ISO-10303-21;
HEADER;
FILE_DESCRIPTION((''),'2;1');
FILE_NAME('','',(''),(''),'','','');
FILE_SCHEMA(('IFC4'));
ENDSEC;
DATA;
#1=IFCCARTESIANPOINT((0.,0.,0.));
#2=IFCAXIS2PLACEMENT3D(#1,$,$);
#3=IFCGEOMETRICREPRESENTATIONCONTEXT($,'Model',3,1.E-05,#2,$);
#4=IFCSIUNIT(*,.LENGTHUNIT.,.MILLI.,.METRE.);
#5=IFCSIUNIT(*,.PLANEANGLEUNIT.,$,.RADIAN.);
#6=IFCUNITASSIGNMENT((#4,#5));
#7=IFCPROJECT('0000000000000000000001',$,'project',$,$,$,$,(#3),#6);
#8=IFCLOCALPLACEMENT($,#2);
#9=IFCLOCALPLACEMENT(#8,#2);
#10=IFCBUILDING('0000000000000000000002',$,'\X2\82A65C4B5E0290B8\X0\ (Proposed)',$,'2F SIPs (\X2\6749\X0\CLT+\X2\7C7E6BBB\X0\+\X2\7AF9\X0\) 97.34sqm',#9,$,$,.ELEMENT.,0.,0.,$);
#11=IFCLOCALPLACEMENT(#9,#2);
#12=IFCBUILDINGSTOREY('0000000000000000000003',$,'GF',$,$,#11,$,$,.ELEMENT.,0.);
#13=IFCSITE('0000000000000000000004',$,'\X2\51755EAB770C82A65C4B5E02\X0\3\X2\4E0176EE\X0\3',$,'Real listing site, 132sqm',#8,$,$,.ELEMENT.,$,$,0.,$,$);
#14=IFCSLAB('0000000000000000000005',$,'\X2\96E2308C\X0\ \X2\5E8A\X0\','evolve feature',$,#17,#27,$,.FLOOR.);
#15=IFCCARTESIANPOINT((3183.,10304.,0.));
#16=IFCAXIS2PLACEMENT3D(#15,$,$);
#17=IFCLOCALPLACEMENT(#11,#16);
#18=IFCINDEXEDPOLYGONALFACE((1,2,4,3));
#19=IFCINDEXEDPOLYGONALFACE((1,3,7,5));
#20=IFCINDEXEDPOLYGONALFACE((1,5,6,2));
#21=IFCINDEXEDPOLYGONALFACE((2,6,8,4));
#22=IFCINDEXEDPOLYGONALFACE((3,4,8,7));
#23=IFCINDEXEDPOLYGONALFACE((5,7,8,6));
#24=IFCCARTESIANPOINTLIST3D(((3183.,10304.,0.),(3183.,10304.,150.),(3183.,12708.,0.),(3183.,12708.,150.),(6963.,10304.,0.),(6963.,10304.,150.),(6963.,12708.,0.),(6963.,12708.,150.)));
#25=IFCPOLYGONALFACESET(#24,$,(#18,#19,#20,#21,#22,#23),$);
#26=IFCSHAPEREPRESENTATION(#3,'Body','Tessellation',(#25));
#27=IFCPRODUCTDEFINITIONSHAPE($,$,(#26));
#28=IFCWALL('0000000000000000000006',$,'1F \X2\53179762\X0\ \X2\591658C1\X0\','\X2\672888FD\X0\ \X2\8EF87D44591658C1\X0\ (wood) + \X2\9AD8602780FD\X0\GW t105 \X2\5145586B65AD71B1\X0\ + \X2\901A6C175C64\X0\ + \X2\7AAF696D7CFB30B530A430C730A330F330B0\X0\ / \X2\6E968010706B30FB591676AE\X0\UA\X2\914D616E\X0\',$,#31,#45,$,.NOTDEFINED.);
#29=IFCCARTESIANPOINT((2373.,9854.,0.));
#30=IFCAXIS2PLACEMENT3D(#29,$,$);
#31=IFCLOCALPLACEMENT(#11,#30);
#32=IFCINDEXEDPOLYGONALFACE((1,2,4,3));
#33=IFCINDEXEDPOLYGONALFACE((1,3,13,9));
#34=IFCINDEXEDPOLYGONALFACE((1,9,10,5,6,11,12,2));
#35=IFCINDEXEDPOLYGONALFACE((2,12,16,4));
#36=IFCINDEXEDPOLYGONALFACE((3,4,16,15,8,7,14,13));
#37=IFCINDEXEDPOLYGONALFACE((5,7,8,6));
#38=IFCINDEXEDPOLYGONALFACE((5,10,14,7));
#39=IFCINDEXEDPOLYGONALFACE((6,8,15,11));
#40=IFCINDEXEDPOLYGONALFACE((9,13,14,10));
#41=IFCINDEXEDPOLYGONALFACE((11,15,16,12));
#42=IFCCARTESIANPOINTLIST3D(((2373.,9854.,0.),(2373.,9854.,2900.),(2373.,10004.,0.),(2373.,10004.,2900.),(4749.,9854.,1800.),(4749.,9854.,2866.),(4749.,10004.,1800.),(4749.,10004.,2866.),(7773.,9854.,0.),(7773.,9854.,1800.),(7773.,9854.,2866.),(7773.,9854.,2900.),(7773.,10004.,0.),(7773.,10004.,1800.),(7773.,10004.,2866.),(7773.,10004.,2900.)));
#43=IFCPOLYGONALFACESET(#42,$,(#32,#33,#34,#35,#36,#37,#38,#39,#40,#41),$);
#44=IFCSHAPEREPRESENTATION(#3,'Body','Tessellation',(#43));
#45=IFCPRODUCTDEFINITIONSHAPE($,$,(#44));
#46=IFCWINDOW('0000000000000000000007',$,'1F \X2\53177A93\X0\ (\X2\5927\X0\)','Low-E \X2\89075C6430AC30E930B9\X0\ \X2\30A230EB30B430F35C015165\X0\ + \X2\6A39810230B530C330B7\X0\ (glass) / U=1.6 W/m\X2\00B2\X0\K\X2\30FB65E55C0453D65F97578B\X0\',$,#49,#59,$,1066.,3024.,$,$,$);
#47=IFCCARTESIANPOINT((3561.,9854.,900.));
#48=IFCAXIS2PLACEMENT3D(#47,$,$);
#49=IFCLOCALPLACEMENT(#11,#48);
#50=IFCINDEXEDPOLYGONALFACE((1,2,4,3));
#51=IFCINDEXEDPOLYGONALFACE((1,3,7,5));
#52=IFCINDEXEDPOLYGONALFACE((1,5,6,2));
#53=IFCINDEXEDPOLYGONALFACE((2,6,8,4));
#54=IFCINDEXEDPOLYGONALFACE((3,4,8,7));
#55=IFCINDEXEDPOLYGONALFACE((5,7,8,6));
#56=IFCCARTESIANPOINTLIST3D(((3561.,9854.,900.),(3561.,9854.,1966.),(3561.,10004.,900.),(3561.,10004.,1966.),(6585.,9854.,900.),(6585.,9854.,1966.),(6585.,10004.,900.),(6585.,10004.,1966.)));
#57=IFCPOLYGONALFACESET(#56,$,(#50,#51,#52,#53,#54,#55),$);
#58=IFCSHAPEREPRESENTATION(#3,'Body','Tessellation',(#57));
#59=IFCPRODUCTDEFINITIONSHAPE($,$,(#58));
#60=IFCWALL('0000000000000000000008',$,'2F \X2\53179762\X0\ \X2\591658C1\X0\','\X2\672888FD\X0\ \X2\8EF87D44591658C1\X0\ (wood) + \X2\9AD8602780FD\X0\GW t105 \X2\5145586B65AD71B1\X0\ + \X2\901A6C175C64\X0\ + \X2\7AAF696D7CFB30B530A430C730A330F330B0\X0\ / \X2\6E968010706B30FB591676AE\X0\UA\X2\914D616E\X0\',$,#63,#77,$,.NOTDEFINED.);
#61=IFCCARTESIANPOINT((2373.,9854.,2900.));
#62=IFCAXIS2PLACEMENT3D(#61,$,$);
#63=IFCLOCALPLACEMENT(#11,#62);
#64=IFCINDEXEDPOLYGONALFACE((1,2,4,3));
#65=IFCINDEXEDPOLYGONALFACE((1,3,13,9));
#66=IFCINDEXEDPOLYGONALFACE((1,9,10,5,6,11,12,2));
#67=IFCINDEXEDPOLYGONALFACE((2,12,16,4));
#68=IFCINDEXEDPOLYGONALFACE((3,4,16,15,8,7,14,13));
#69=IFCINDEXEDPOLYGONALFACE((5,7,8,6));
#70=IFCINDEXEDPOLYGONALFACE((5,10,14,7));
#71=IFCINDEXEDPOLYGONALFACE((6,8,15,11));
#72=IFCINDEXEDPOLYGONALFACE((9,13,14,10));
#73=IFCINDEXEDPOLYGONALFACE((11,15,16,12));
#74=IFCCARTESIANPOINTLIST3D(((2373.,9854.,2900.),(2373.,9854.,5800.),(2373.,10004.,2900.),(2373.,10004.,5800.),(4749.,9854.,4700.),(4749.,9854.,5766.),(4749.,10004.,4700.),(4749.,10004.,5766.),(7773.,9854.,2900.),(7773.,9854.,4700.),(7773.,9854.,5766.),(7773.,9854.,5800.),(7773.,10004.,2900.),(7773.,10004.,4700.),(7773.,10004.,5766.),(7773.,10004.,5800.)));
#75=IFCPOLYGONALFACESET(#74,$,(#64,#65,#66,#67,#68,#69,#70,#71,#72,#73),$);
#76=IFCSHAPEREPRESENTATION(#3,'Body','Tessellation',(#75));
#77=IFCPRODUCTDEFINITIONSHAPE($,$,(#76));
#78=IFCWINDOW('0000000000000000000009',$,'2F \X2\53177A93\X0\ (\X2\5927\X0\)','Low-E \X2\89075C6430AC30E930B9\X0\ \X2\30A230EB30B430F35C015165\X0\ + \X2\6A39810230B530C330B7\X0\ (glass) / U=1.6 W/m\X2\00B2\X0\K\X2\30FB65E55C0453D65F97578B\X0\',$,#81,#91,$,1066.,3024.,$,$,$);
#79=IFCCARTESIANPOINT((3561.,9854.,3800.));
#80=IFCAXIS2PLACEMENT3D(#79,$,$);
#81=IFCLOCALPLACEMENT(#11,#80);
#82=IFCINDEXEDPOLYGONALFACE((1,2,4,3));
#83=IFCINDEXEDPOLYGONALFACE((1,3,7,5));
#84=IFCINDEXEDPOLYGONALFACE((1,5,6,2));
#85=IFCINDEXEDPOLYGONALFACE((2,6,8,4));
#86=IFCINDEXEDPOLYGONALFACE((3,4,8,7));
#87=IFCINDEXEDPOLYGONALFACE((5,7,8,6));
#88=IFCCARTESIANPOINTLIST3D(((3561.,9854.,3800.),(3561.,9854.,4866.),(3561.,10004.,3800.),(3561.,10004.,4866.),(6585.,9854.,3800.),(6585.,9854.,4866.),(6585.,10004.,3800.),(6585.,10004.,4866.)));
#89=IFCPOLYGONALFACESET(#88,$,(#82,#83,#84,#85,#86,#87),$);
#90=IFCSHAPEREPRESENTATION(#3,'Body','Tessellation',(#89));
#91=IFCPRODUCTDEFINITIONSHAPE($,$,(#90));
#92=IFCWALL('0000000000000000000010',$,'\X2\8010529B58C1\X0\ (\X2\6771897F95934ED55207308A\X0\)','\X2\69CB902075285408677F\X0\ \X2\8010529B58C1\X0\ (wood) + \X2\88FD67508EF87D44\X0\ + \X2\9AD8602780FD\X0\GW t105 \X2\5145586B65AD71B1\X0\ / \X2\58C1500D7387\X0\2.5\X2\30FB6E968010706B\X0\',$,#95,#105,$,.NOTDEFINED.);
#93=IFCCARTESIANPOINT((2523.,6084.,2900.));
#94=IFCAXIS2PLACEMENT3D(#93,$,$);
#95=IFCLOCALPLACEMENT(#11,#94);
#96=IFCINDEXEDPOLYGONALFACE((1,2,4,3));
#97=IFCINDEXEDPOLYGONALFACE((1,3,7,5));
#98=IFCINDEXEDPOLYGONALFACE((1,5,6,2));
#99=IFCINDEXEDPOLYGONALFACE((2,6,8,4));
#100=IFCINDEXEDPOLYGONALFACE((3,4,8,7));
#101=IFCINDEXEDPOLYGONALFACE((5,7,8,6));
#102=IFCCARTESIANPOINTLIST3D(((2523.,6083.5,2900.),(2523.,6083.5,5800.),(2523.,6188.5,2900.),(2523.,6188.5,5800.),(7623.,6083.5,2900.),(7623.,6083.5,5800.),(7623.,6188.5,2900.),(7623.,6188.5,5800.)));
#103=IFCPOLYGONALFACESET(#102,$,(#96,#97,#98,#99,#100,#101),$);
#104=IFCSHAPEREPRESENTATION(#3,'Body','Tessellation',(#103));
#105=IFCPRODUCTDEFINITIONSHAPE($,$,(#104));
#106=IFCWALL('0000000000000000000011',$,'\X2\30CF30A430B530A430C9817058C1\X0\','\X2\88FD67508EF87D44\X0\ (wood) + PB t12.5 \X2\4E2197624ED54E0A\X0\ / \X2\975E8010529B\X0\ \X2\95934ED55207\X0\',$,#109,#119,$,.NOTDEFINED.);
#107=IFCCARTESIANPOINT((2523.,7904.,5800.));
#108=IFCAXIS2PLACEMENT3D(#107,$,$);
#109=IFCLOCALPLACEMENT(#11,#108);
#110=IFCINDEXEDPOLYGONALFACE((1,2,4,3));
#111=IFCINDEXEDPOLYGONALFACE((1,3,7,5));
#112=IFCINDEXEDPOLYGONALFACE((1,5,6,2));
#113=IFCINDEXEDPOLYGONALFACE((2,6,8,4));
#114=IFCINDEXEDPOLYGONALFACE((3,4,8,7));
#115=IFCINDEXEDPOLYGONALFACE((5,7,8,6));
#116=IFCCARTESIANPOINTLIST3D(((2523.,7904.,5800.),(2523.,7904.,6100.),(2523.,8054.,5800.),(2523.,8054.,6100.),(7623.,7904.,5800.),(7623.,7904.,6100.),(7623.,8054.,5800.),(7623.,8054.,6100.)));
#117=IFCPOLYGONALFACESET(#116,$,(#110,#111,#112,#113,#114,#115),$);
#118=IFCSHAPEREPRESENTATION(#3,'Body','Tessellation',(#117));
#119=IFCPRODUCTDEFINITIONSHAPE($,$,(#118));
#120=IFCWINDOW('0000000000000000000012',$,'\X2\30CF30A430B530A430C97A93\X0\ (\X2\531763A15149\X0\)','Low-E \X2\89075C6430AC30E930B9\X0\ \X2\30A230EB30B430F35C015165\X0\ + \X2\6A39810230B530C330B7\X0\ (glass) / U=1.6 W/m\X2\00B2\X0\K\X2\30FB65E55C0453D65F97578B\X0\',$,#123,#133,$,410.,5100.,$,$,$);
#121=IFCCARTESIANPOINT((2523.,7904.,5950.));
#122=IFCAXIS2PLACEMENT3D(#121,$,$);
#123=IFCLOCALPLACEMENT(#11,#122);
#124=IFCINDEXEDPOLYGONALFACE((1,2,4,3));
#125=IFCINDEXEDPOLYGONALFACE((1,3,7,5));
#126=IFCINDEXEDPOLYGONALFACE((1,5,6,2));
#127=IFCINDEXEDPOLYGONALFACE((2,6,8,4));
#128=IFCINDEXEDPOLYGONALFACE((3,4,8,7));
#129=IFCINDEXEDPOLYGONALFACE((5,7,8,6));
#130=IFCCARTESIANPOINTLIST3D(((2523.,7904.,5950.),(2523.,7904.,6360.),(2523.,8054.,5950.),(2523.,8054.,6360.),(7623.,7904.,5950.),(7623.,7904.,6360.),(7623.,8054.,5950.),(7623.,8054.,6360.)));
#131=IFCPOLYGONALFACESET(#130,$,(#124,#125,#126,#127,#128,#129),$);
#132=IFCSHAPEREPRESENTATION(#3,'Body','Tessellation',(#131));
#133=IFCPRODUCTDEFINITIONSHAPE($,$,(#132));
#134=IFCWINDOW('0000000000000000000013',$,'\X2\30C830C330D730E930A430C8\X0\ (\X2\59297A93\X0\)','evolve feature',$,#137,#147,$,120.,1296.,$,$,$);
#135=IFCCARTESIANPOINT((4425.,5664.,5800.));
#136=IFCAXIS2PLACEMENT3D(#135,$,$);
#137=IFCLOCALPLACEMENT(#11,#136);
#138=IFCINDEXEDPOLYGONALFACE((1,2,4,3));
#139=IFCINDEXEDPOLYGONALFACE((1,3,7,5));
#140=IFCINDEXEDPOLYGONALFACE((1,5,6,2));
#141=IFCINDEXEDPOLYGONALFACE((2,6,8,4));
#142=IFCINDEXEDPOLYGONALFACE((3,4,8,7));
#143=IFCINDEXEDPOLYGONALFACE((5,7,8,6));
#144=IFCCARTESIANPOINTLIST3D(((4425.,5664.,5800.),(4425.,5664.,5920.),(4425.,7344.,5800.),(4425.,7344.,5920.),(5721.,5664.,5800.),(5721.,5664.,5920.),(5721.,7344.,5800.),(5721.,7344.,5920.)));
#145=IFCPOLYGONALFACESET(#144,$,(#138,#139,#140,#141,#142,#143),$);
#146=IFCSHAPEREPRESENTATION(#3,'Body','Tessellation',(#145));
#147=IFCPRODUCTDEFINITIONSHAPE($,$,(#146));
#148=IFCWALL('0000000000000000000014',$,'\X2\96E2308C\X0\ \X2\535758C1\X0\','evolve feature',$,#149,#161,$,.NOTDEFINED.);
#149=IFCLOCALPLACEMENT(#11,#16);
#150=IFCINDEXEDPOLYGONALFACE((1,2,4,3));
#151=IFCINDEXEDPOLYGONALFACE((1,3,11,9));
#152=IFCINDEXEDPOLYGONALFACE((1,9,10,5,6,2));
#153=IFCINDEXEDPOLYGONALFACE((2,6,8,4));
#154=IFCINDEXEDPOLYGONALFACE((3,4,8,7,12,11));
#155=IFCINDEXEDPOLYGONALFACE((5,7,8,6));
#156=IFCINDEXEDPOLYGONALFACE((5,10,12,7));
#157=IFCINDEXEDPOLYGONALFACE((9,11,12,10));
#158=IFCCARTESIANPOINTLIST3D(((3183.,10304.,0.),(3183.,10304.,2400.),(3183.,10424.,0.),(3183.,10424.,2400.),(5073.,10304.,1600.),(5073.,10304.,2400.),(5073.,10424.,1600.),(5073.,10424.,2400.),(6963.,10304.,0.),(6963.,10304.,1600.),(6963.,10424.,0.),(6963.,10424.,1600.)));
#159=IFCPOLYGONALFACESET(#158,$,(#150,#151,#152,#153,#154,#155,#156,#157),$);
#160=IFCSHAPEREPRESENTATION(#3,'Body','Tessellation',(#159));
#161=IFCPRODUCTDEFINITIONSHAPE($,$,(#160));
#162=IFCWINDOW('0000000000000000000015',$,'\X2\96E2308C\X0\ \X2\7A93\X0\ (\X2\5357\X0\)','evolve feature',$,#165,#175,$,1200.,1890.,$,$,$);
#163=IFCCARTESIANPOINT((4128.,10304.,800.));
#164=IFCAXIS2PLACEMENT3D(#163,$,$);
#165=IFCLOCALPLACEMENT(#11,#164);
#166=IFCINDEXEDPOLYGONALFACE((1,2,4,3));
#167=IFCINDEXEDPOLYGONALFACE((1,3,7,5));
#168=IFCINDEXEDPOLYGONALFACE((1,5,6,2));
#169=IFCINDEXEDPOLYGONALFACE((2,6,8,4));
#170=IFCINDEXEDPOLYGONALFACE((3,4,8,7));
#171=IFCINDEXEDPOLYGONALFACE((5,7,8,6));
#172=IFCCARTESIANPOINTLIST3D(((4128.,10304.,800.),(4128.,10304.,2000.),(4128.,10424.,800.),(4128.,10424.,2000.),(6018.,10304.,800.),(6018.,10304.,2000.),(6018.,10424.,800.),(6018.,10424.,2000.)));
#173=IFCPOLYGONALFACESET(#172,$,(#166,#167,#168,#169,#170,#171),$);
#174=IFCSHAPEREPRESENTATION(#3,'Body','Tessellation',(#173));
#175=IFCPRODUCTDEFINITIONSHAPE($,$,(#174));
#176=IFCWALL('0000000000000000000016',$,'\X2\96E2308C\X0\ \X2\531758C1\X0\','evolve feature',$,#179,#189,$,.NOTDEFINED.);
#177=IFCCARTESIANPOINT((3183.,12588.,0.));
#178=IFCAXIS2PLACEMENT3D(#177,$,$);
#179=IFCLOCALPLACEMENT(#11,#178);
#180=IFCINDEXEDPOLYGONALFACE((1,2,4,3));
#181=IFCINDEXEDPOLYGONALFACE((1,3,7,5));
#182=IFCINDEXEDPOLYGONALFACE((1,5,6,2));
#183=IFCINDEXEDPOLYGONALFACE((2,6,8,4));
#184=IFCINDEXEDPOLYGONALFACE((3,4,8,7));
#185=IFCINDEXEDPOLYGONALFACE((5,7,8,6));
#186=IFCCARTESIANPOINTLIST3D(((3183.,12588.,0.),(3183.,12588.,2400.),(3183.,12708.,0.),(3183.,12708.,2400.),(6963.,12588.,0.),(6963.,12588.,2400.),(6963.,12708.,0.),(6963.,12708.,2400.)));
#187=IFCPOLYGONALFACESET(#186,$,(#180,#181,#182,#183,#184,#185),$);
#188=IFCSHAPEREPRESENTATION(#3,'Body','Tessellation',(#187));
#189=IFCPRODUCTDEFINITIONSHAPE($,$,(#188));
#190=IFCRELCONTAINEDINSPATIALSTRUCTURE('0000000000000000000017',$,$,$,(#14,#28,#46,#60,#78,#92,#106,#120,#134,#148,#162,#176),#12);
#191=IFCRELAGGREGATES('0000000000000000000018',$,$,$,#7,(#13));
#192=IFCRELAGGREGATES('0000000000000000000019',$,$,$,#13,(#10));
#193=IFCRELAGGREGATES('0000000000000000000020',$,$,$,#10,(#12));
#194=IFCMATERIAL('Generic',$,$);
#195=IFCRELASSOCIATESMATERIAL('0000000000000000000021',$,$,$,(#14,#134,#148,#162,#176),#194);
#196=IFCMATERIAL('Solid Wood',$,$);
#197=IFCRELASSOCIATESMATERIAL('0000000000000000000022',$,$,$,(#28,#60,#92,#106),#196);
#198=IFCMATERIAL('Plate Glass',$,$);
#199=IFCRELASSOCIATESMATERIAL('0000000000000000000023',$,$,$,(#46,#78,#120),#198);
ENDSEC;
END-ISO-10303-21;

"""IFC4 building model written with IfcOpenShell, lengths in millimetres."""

from ifc_helpers import new_model, si_unit, frame, frame_2d, origin, place, context, project, spatial, rectangle, extrude, material, element, fill, save


model = new_model("IFC4")

# Units and contexts
model_context = context("Model", 3, precision=1e-05, world=origin())
ifc_project = project(units=[si_unit("LENGTHUNIT", "METRE", prefix="MILLI"), si_unit("PLANEANGLEUNIT", "RADIAN")], contexts=[model_context])

# Site, building, storey
site_placement = place(None, origin())
site = spatial("IfcSite", under=ifc_project, at=site_placement, Name="兵庫県芦屋市3丁目3", ObjectType="Real listing site, 132sqm", CompositionType="ELEMENT", RefElevation=0.0)
building_placement = place(site_placement, origin())
building = spatial("IfcBuilding", under=site, at=building_placement, Name="芦屋市邸 (Proposed)", ObjectType="2F SIPs (杉CLT+籾殻+竹) 97.34sqm", CompositionType="ELEMENT", ElevationOfRefHeight=0.0, ElevationOfTerrain=0.0)
storey_placement = place(building_placement, origin())
storey = spatial("IfcBuildingStorey", under=building, at=storey_placement, Name="GF", CompositionType="ELEMENT", Elevation=0.0)

# Slab
ifc_material_1 = material(Name="Generic")
slab_placement = place(storey_placement, frame((3183.0, 10304.0, 0.0)))
element("IfcSlab", 1, at=slab_placement, inside=storey, material=ifc_material_1, Name="離れ 床", Description="evolve feature", PredefinedType="FLOOR", context=model_context, shape_type="SweptSolid", body=[
    extrude(rectangle(XDim=3780.0, YDim=2404.0, at=frame_2d((1890.0, 1202.0))), frame((3183.0, 10304.0, 0.0)), (0.0, 0.0, 1.0), 150.0),
])

# Wall, opening, window
ifc_material_2 = material(Name="Solid Wood")
wall_1_placement = place(storey_placement, frame((2373.0, 9854.0, 0.0)))
wall_1 = element("IfcWall", 2, at=wall_1_placement, inside=storey, material=ifc_material_2, Name="1F 北面 外壁", Description="木製 軸組外壁 (wood) + 高性能GW t105 充填断熱 + 通気層 + 窯業系サイディング / 準耐火・外皮UA配慮", PredefinedType="NOTDEFINED", context=model_context, shape_type="SweptSolid", body=[
    extrude(rectangle(XDim=5400.0, YDim=150.0, at=frame_2d((2700.0, 75.0))), frame((2373.0, 9854.0, 0.0)), (0.0, 0.0, 1.0), 2900.0),
])
opening_1_placement = place(storey_placement, frame((3561.0, 9854.0, 900.0)))
opening_1 = element("IfcOpeningElement", 3, at=opening_1_placement, cuts=wall_1, PredefinedType="NOTDEFINED", context=model_context, shape_type="SweptSolid", body=[
    extrude(rectangle(XDim=3024.0, YDim=150.0, at=frame_2d((1512.0, 75.0))), frame((3561.0, 9854.0, 900.0)), (0.0, 0.0, 1.0), 1066.0),
])
ifc_material_3 = material(Name="Plate Glass")
window_1_placement = place(storey_placement, frame((3561.0, 9854.0, 900.0)))
window_1 = element("IfcWindow", 4, at=window_1_placement, inside=storey, material=ifc_material_3, Name="1F 北窓 (大)", Description="Low-E 複層ガラス アルゴン封入 + 樹脂サッシ (glass) / U=1.6 W/m²K・日射取得型", OverallHeight=1066.0, OverallWidth=3024.0, context=model_context, shape_type="SweptSolid", body=[
    extrude(rectangle(XDim=3024.0, YDim=150.0, at=frame_2d((1512.0, 75.0))), frame((3561.0, 9854.0, 900.0)), (0.0, 0.0, 1.0), 1066.0),
])
fill(opening_1, window_1)

# Wall, opening, window
wall_2_placement = place(storey_placement, frame((2373.0, 9854.0, 2900.0)))
wall_2 = element("IfcWall", 5, at=wall_2_placement, inside=storey, material=ifc_material_2, Name="2F 北面 外壁", Description="木製 軸組外壁 (wood) + 高性能GW t105 充填断熱 + 通気層 + 窯業系サイディング / 準耐火・外皮UA配慮", PredefinedType="NOTDEFINED", context=model_context, shape_type="SweptSolid", body=[
    extrude(rectangle(XDim=5400.0, YDim=150.0, at=frame_2d((2700.0, 75.0))), frame((2373.0, 9854.0, 2900.0)), (0.0, 0.0, 1.0), 2900.0),
])
opening_2_placement = place(storey_placement, frame((3561.0, 9854.0, 3800.0)))
opening_2 = element("IfcOpeningElement", 6, at=opening_2_placement, cuts=wall_2, PredefinedType="NOTDEFINED", context=model_context, shape_type="SweptSolid", body=[
    extrude(rectangle(XDim=3024.0, YDim=150.0, at=frame_2d((1512.0, 75.0))), frame((3561.0, 9854.0, 3800.0)), (0.0, 0.0, 1.0), 1066.0),
])
window_2_placement = place(storey_placement, frame((3561.0, 9854.0, 3800.0)))
window_2 = element("IfcWindow", 7, at=window_2_placement, inside=storey, material=ifc_material_3, Name="2F 北窓 (大)", Description="Low-E 複層ガラス アルゴン封入 + 樹脂サッシ (glass) / U=1.6 W/m²K・日射取得型", OverallHeight=1066.0, OverallWidth=3024.0, context=model_context, shape_type="SweptSolid", body=[
    extrude(rectangle(XDim=3024.0, YDim=150.0, at=frame_2d((1512.0, 75.0))), frame((3561.0, 9854.0, 3800.0)), (0.0, 0.0, 1.0), 1066.0),
])
fill(opening_2, window_2)

# Wall
wall_3_placement = place(storey_placement, frame((2523.0, 6084.0, 2900.0)))
element("IfcWall", 8, at=wall_3_placement, inside=storey, material=ifc_material_2, Name="耐力壁 (東西間仕切り)", Description="構造用合板 耐力壁 (wood) + 製材軸組 + 高性能GW t105 充填断熱 / 壁倍率2.5・準耐火", PredefinedType="NOTDEFINED", context=model_context, shape_type="SweptSolid", body=[
    extrude(rectangle(XDim=5100.0, YDim=105.0, at=frame_2d((2550.0, 52.0))), frame((2523.0, 6084.0, 2900.0)), (0.0, 0.0, 1.0), 2900.0),
])

# Wall, opening, window
wall_4_placement = place(storey_placement, frame((2523.0, 7904.0, 5800.0)))
wall_4 = element("IfcWall", 9, at=wall_4_placement, inside=storey, material=ifc_material_2, Name="ハイサイド腰壁", Description="製材軸組 (wood) + PB t12.5 両面仕上 / 非耐力 間仕切", PredefinedType="NOTDEFINED", context=model_context, shape_type="SweptSolid", body=[
    extrude(rectangle(XDim=5100.0, YDim=150.0, at=frame_2d((2550.0, 75.0))), frame((2523.0, 7904.0, 5800.0)), (0.0, 0.0, 1.0), 700.0),
])
opening_3_placement = place(storey_placement, frame((2523.0, 7904.0, 5950.0)))
opening_3 = element("IfcOpeningElement", 10, at=opening_3_placement, cuts=wall_4, PredefinedType="NOTDEFINED", context=model_context, shape_type="SweptSolid", body=[
    extrude(rectangle(XDim=5100.0, YDim=150.0, at=frame_2d((2550.0, 75.0))), frame((2523.0, 7904.0, 5950.0)), (0.0, 0.0, 1.0), 410.0),
])
window_3_placement = place(storey_placement, frame((2523.0, 7904.0, 5950.0)))
window_3 = element("IfcWindow", 11, at=window_3_placement, inside=storey, material=ifc_material_3, Name="ハイサイド窓 (北採光)", Description="Low-E 複層ガラス アルゴン封入 + 樹脂サッシ (glass) / U=1.6 W/m²K・日射取得型", OverallHeight=410.0, OverallWidth=5100.0, context=model_context, shape_type="SweptSolid", body=[
    extrude(rectangle(XDim=5100.0, YDim=150.0, at=frame_2d((2550.0, 75.0))), frame((2523.0, 7904.0, 5950.0)), (0.0, 0.0, 1.0), 410.0),
])
fill(opening_3, window_3)

# Window
window_4_placement = place(storey_placement, frame((4425.0, 5664.0, 5800.0)))
element("IfcWindow", 12, at=window_4_placement, inside=storey, material=ifc_material_1, Name="トップライト (天窓)", Description="evolve feature", OverallHeight=120.0, OverallWidth=1296.0, context=model_context, shape_type="SweptSolid", body=[
    extrude(rectangle(XDim=1296.0, YDim=1680.0, at=frame_2d((648.0, 840.0))), frame((4425.0, 5664.0, 5800.0)), (0.0, 0.0, 1.0), 120.0),
])

# Wall, opening, window
wall_5_placement = place(storey_placement, frame((3183.0, 10304.0, 0.0)))
wall_5 = element("IfcWall", 13, at=wall_5_placement, inside=storey, material=ifc_material_1, Name="離れ 南壁", Description="evolve feature", PredefinedType="NOTDEFINED", context=model_context, shape_type="SweptSolid", body=[
    extrude(rectangle(XDim=3780.0, YDim=120.0, at=frame_2d((1890.0, 60.0))), frame((3183.0, 10304.0, 0.0)), (0.0, 0.0, 1.0), 2400.0),
])
opening_4_placement = place(storey_placement, frame((4128.0, 10304.0, 800.0)))
opening_4 = element("IfcOpeningElement", 14, at=opening_4_placement, cuts=wall_5, PredefinedType="NOTDEFINED", context=model_context, shape_type="SweptSolid", body=[
    extrude(rectangle(XDim=1890.0, YDim=120.0, at=frame_2d((945.0, 60.0))), frame((4128.0, 10304.0, 800.0)), (0.0, 0.0, 1.0), 1200.0),
])
window_5_placement = place(storey_placement, frame((4128.0, 10304.0, 800.0)))
window_5 = element("IfcWindow", 15, at=window_5_placement, inside=storey, material=ifc_material_1, Name="離れ 窓 (南)", Description="evolve feature", OverallHeight=1200.0, OverallWidth=1890.0, context=model_context, shape_type="SweptSolid", body=[
    extrude(rectangle(XDim=1890.0, YDim=120.0, at=frame_2d((945.0, 60.0))), frame((4128.0, 10304.0, 800.0)), (0.0, 0.0, 1.0), 1200.0),
])
fill(opening_4, window_5)

# Wall
wall_6_placement = place(storey_placement, frame((3183.0, 12588.0, 0.0)))
element("IfcWall", 16, at=wall_6_placement, inside=storey, material=ifc_material_1, Name="離れ 北壁", Description="evolve feature", PredefinedType="NOTDEFINED", context=model_context, shape_type="SweptSolid", body=[
    extrude(rectangle(XDim=3780.0, YDim=120.0, at=frame_2d((1890.0, 60.0))), frame((3183.0, 12588.0, 0.0)), (0.0, 0.0, 1.0), 2400.0),
])

save(model, "model.ifc")
